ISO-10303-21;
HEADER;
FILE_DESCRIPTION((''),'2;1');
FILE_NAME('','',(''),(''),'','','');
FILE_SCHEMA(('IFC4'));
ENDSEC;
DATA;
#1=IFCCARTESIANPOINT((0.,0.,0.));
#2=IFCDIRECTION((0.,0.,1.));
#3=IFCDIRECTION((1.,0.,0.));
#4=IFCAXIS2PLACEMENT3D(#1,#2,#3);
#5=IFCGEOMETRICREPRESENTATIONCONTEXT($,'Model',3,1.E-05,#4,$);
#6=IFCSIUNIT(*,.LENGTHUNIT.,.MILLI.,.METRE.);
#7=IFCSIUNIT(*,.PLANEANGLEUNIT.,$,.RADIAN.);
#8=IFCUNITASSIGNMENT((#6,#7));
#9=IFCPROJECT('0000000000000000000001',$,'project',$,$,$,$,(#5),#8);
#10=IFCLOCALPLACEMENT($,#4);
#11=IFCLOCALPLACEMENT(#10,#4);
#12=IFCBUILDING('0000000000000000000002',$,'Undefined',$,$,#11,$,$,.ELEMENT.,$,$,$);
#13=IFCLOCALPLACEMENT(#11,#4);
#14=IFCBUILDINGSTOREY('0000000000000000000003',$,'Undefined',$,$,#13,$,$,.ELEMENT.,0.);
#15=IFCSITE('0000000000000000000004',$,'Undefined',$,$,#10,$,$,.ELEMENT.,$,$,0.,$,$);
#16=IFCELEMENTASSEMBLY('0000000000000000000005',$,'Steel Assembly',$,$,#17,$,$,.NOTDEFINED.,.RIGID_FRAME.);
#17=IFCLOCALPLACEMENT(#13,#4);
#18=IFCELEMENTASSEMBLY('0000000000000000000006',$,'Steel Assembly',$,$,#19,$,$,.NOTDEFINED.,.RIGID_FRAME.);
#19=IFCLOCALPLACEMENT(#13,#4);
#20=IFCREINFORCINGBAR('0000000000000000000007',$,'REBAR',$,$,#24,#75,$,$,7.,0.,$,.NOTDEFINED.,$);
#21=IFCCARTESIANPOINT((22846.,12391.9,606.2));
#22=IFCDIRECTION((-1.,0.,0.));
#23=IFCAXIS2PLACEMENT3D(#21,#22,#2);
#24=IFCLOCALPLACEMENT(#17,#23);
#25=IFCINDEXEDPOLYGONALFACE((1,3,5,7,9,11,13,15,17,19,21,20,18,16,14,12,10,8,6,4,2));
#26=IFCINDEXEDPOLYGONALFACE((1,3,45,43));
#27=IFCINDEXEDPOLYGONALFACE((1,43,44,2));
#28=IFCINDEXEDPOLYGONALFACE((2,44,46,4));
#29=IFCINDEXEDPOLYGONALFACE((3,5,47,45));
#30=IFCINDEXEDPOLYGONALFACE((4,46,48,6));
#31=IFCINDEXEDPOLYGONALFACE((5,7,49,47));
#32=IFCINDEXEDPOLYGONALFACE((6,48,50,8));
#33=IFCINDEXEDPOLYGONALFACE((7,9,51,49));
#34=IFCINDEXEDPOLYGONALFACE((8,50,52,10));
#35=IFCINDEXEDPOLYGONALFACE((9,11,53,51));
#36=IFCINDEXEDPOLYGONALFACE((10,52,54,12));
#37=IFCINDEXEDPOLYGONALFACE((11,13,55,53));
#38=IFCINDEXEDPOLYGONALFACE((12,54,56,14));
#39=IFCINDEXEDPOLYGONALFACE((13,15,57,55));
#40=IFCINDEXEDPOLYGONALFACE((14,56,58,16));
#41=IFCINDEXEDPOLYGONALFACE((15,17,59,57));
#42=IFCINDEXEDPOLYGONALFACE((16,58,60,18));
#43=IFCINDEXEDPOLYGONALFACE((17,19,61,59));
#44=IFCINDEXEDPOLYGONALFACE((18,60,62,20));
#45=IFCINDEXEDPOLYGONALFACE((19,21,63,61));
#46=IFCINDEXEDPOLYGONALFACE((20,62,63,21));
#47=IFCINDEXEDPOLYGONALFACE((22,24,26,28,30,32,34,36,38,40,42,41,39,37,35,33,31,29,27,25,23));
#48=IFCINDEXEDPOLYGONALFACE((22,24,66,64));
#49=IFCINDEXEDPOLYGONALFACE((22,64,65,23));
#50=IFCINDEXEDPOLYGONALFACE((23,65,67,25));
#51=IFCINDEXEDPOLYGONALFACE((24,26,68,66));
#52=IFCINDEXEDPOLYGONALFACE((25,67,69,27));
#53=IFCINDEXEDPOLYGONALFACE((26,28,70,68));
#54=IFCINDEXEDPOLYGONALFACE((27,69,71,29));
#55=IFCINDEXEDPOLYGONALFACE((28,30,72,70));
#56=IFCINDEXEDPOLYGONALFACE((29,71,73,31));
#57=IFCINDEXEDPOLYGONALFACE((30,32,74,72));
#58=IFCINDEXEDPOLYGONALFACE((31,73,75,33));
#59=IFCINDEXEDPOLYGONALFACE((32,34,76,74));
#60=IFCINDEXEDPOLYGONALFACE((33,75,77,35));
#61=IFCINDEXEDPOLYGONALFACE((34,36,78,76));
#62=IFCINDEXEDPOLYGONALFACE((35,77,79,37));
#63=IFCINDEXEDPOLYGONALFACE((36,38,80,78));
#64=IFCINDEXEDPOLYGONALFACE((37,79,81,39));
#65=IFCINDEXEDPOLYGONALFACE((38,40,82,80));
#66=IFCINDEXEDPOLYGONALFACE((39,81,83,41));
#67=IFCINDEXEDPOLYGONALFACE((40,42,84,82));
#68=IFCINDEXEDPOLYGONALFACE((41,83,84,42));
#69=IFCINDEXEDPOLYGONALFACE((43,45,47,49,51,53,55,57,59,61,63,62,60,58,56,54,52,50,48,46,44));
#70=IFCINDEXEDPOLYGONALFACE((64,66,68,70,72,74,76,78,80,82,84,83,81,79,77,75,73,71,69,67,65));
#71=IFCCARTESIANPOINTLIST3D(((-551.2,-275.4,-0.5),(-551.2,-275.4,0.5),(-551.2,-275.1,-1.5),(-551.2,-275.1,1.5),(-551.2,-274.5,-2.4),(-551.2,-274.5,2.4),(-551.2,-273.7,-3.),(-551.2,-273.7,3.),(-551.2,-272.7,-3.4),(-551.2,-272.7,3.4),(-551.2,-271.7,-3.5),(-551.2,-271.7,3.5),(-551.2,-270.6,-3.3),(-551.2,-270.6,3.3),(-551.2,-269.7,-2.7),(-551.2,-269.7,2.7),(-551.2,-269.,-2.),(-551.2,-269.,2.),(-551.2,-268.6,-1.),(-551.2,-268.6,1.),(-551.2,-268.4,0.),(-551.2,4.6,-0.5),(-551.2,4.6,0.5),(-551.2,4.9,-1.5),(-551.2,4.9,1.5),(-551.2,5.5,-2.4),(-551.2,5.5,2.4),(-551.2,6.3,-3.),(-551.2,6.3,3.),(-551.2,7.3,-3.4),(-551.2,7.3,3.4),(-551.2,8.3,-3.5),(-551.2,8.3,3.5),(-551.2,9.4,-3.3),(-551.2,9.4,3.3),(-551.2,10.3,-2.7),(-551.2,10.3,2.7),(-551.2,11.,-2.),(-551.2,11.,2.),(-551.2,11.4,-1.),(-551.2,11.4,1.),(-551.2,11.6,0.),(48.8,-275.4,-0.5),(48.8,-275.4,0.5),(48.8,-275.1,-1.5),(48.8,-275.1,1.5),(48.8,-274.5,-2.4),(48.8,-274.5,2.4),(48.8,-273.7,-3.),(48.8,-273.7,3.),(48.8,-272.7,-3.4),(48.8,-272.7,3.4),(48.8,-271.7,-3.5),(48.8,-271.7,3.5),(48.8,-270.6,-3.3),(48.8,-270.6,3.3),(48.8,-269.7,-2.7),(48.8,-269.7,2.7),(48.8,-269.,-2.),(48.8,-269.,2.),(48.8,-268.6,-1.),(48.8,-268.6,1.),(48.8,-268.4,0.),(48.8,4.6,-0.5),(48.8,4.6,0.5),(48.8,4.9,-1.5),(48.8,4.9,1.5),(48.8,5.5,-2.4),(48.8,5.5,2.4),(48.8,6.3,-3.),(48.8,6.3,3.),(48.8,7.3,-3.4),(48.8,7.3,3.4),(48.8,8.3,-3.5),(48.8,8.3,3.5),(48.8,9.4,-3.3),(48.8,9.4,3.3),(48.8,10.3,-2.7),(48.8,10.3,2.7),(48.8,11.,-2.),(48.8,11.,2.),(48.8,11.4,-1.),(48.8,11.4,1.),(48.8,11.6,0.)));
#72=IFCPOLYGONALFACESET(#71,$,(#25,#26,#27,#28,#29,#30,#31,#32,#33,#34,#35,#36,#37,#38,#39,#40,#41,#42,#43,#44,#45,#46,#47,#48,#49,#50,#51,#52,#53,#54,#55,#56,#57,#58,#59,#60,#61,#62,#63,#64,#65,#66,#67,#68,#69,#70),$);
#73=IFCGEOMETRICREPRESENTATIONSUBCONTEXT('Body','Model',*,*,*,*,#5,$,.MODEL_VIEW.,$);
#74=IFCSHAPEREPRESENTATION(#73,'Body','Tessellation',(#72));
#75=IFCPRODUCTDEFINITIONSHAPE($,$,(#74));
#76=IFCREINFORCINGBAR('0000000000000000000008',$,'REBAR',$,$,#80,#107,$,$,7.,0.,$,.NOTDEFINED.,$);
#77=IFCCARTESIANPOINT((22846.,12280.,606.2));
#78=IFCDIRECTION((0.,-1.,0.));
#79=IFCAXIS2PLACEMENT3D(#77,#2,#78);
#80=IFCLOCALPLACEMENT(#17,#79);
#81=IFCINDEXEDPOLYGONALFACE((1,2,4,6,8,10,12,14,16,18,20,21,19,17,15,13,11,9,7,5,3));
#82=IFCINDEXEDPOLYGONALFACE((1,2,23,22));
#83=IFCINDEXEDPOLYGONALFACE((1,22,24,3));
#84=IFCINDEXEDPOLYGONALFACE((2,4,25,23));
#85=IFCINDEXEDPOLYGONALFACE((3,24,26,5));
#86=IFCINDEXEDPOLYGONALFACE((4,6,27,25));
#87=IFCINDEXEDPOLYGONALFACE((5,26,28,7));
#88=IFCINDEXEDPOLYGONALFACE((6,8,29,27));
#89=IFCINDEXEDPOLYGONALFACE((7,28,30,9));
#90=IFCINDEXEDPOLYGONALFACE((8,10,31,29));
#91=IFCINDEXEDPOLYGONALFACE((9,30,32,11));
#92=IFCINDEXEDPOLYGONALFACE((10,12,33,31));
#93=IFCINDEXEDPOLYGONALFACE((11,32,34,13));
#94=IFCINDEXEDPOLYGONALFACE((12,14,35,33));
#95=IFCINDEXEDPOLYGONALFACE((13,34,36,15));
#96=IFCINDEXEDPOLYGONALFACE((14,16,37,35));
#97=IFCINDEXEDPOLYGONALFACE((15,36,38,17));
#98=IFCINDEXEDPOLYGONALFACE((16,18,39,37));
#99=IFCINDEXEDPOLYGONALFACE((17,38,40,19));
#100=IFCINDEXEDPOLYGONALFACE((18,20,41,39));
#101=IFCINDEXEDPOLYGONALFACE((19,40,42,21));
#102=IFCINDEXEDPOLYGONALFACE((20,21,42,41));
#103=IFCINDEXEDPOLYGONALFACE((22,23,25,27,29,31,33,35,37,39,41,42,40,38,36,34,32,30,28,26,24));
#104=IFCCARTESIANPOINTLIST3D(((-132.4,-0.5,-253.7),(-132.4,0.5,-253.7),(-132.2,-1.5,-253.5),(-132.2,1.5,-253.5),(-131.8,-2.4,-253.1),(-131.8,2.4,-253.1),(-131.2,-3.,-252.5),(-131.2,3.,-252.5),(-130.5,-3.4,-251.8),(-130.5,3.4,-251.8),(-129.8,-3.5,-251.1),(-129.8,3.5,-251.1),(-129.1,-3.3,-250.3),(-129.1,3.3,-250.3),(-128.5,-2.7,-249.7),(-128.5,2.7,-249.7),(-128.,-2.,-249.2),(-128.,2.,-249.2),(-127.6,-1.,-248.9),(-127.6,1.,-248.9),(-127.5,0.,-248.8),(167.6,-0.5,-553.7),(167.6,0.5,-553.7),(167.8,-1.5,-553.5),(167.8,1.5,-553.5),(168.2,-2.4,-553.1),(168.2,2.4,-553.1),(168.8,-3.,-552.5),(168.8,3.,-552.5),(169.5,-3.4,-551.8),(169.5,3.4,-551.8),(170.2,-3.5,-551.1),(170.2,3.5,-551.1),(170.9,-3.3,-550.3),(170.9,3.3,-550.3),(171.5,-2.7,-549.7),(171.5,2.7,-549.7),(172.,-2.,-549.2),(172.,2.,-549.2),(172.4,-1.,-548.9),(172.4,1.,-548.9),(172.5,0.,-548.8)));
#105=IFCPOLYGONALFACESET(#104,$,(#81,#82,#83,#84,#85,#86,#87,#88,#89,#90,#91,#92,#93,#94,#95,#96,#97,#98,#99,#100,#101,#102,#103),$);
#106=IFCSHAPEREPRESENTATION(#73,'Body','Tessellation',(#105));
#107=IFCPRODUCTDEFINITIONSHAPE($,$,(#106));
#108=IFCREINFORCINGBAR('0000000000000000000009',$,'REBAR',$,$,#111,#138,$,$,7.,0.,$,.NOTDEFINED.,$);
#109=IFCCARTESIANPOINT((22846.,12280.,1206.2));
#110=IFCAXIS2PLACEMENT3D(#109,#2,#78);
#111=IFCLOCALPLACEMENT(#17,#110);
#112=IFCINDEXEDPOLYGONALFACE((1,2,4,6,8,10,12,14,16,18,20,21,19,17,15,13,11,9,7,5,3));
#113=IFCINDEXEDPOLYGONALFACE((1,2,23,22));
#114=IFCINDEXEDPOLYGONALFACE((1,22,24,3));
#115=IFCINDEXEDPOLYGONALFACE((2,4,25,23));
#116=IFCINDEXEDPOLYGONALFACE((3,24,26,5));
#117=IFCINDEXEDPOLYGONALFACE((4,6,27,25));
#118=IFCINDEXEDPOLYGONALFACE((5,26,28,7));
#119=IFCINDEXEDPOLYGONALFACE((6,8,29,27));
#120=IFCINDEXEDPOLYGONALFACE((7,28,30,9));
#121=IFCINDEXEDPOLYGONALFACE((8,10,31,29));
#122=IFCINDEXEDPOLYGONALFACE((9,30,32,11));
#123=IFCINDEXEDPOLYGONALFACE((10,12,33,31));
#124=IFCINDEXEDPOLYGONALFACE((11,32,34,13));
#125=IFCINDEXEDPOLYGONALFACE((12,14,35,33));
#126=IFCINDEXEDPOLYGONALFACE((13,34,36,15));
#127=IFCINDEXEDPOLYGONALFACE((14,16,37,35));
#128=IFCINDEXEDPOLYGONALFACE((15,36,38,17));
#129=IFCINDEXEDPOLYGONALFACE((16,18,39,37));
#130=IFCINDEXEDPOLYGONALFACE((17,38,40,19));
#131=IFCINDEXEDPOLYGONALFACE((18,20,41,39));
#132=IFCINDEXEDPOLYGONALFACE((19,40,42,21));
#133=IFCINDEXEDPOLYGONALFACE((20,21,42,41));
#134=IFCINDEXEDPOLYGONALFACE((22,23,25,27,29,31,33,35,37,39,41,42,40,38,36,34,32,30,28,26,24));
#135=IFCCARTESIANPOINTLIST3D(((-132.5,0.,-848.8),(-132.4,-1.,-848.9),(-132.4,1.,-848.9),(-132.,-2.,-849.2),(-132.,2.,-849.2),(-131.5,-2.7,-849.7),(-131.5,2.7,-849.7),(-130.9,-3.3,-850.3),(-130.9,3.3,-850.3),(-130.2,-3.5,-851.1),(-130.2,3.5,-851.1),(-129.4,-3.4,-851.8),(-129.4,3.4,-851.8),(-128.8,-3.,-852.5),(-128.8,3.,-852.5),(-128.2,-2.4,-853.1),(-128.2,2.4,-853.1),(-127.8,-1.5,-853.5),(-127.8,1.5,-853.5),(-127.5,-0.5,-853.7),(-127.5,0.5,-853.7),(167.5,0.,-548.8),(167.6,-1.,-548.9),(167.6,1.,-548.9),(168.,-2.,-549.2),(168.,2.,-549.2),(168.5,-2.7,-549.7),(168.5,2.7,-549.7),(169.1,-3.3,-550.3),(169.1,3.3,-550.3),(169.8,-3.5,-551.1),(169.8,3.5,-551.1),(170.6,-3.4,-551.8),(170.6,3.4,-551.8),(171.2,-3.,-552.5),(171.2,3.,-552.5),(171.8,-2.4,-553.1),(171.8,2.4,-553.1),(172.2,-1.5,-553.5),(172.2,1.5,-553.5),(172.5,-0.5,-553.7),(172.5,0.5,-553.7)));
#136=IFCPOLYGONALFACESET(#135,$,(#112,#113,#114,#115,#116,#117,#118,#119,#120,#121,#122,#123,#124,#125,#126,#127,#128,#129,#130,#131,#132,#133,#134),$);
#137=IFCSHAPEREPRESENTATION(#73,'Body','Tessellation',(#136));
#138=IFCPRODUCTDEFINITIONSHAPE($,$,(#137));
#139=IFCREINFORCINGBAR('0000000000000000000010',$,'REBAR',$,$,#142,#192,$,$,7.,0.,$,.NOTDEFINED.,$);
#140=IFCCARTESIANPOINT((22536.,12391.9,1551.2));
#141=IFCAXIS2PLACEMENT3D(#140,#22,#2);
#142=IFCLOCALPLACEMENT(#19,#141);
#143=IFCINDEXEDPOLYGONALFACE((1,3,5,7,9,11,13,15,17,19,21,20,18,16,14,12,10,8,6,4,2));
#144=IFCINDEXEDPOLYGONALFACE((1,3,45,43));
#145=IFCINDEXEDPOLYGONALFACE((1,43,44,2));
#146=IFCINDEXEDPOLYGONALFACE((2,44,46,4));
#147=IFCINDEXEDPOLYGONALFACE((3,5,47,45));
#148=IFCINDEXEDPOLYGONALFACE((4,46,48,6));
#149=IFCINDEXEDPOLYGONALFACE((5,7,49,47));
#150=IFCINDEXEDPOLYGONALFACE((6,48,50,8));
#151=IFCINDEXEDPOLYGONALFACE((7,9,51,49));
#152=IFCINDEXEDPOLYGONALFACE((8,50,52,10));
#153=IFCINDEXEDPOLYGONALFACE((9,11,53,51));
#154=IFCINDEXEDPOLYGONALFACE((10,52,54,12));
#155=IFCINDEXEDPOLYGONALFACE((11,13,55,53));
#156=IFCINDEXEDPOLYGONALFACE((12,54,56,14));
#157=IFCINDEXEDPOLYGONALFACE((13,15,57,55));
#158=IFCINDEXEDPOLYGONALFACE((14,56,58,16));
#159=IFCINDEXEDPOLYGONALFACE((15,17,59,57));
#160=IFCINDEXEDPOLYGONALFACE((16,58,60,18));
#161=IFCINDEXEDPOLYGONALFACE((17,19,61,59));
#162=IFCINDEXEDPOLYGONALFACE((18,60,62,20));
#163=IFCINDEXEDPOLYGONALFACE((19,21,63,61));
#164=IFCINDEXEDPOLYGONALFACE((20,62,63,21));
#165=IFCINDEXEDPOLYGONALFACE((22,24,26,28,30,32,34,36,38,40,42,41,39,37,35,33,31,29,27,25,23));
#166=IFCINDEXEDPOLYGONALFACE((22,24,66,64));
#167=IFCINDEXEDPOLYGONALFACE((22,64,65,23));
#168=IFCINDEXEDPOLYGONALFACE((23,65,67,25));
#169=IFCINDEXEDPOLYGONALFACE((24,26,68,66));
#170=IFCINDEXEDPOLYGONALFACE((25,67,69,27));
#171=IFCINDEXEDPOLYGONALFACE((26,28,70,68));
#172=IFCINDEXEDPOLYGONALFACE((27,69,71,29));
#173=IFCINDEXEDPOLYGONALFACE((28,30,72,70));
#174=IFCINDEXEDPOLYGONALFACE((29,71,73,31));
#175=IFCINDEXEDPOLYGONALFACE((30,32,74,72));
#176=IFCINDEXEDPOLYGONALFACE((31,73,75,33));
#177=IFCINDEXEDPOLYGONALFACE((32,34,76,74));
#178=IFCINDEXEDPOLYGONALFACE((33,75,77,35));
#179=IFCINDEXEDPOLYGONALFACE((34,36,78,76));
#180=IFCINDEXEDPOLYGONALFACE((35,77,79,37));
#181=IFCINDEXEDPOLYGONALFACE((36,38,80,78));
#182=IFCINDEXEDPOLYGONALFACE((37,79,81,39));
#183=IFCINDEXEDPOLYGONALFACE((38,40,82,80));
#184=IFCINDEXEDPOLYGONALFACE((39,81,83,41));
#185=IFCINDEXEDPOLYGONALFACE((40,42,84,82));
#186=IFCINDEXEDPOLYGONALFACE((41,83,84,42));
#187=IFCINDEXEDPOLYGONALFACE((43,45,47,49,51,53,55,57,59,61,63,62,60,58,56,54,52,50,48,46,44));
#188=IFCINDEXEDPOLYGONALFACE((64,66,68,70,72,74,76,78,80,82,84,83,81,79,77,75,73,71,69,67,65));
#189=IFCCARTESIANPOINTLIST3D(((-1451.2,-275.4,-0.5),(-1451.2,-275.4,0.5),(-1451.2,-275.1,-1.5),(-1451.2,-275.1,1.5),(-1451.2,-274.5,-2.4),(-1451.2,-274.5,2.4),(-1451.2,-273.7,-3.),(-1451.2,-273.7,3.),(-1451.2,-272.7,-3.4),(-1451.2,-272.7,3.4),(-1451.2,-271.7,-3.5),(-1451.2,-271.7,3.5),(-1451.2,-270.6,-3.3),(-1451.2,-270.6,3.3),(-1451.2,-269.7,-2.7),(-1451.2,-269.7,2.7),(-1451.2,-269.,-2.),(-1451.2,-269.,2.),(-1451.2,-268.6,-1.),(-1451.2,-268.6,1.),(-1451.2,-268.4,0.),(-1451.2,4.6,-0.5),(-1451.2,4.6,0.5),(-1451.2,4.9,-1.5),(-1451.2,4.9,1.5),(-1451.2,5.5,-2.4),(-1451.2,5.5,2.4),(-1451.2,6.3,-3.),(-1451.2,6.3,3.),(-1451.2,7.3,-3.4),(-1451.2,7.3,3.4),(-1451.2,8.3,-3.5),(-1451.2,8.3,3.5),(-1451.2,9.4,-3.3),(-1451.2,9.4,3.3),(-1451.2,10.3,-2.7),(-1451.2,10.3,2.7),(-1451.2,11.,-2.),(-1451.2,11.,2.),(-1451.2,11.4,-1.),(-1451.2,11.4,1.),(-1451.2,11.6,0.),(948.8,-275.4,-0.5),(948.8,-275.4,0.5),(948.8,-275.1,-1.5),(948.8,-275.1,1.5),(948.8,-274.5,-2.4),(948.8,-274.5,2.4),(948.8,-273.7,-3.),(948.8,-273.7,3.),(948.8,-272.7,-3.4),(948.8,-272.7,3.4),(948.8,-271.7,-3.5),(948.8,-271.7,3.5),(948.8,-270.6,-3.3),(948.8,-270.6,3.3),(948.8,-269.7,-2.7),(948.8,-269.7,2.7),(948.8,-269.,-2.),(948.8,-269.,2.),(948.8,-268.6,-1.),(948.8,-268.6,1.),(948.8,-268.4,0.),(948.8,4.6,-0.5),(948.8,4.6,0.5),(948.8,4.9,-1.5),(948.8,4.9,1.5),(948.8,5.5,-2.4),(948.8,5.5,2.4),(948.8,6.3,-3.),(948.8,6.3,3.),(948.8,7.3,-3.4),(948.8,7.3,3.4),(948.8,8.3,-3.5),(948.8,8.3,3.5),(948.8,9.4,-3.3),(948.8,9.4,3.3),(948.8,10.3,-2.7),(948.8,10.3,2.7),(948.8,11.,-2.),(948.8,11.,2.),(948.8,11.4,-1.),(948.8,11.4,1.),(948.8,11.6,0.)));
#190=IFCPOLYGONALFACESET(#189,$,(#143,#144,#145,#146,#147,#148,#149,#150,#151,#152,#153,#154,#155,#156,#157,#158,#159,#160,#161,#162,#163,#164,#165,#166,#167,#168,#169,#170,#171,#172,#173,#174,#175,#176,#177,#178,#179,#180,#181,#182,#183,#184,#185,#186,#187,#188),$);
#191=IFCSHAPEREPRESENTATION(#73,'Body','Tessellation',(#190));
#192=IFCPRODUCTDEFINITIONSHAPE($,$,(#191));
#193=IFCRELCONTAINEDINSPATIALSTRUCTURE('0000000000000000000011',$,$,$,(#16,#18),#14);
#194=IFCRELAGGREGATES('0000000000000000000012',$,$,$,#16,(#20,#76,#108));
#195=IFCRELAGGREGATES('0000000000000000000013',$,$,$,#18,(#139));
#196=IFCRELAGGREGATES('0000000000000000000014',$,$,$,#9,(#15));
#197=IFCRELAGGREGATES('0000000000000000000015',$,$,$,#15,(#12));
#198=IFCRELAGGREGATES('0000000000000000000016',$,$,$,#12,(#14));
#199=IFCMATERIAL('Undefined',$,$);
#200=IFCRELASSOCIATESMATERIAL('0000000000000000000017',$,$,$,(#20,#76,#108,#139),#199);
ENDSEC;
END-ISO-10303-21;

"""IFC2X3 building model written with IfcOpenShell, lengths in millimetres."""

from ifc_helpers import new_model, entity, si_unit, frame, origin_with_axes, place, context, subcontext, project, spatial, source, transform, mapped, material, element, aggregate, save


model = new_model("IFC2X3")

# Units and contexts
model_context = context("Model", 3, precision=1e-05, world=origin_with_axes())
body_context = subcontext(model_context, "Body", "Model", "MODEL_VIEW")
ifc_project = project(units=[si_unit("LENGTHUNIT", "METRE", prefix="MILLI"), si_unit("PLANEANGLEUNIT", "RADIAN")], contexts=[model_context])

# Site, building, storey
site_placement = place(None, origin_with_axes())
site = spatial("IfcSite", under=ifc_project, at=site_placement, Name="Undefined", CompositionType="ELEMENT", RefElevation=0.0)
building_placement = place(site_placement, origin_with_axes())
building = spatial("IfcBuilding", under=site, at=building_placement, Name="Undefined", CompositionType="ELEMENT")
storey_placement = place(building_placement, origin_with_axes())
storey = spatial("IfcBuildingStorey", under=building, at=storey_placement, Name="Undefined", CompositionType="ELEMENT", Elevation=0.0)

# Element assemblies
assembly_1_placement = place(storey_placement, origin_with_axes())
assembly_1 = element("IfcElementAssembly", 1, at=assembly_1_placement, inside=storey, Name="Steel Assembly", AssemblyPlace="NOTDEFINED", PredefinedType="RIGID_FRAME")
assembly_2_placement = place(storey_placement, origin_with_axes())
assembly_2 = element("IfcElementAssembly", 2, at=assembly_2_placement, inside=storey, Name="Steel Assembly", AssemblyPlace="NOTDEFINED", PredefinedType="RIGID_FRAME")

# Shared definitions
ifc_material_1 = material(Name="Undefined")

# Reinforcing bars
shared_shape_1 = source(origin_with_axes(), body_context, "Body", "AdvancedSweptSolid", [
    entity("IfcSweptDiskSolid", entity("IfcTrimmedCurve", entity("IfcLine", entity("IfcCartesianPoint", [0.0, 0.0, 0.0]), entity("IfcVector", entity("IfcDirection", [1.0, 0.00001, 0.0]), 1.0)), [entity("IfcParameterValue", 0.0)], [entity("IfcParameterValue", 600.0)], True, "PARAMETER"), 3.5, None, 0.0, 600.0),
])
shared_shape_2 = source(origin_with_axes(), body_context, "Body", "AdvancedSweptSolid", [
    entity("IfcSweptDiskSolid", entity("IfcTrimmedCurve", entity("IfcLine", entity("IfcCartesianPoint", [0.0, 0.0, 0.0]), entity("IfcVector", entity("IfcDirection", [1.0, 0.00001, 0.0]), 1.0)), [entity("IfcParameterValue", 0.0)], [entity("IfcParameterValue", 600.0)], True, "PARAMETER"), 3.5, None, 0.0, 600.0),
])
reinforcing_bar_1_placement = place(assembly_1_placement, frame((22846.0, 12391.9, 606.2), z_axis=(-1.0, 0.0, 0.0), x_axis=(0.0, 0.0, 1.0)))
reinforcing_bar_1 = element("IfcReinforcingBar", 3, at=reinforcing_bar_1_placement, material=ifc_material_1, Name="REBAR", BarRole="NOTDEFINED", CrossSectionArea=0.0, NominalDiameter=7.0, context=body_context, shape_type="MappedRepresentation", body=[
    mapped(shared_shape_1, transform((-551.2, -271.9, 0.0))),
    mapped(shared_shape_2, transform((-551.2, 8.1, 0.0))),
])
shared_shape_3 = source(origin_with_axes(), body_context, "Body", "AdvancedSweptSolid", [
    entity("IfcSweptDiskSolid", entity("IfcTrimmedCurve", entity("IfcLine", entity("IfcCartesianPoint", [0.0, 0.0, 0.0]), entity("IfcVector", entity("IfcDirection", [0.707107, 0.0, -0.707107]), 1.0)), [entity("IfcParameterValue", 0.0)], [entity("IfcParameterValue", 424.264069)], True, "PARAMETER"), 3.5, None, 0.0, 424.3),
])
reinforcing_bar_2_placement = place(assembly_1_placement, frame((22846.0, 12280.0, 606.2), z_axis=(0.0, 0.0, 1.0), x_axis=(0.0, -1.0, 0.0)))
reinforcing_bar_2 = element("IfcReinforcingBar", 4, at=reinforcing_bar_2_placement, material=ifc_material_1, Name="REBAR", BarRole="NOTDEFINED", CrossSectionArea=0.0, NominalDiameter=7.0, context=body_context, shape_type="MappedRepresentation", body=[
    mapped(shared_shape_3, transform((-130.0, 0.0, -251.2))),
])
shared_shape_4 = source(origin_with_axes(), body_context, "Body", "AdvancedSweptSolid", [
    entity("IfcSweptDiskSolid", entity("IfcTrimmedCurve", entity("IfcLine", entity("IfcCartesianPoint", [0.0, 0.0, 0.0]), entity("IfcVector", entity("IfcDirection", [0.707107, 0.0, 0.707107]), 1.0)), [entity("IfcParameterValue", 0.0)], [entity("IfcParameterValue", 424.264069)], True, "PARAMETER"), 3.5, None, 0.0, 424.3),
])
reinforcing_bar_3_placement = place(assembly_1_placement, frame((22846.0, 12280.0, 1206.2), z_axis=(0.0, 0.0, 1.0), x_axis=(0.0, -1.0, 0.0)))
reinforcing_bar_3 = element("IfcReinforcingBar", 5, at=reinforcing_bar_3_placement, material=ifc_material_1, Name="REBAR", BarRole="NOTDEFINED", CrossSectionArea=0.0, NominalDiameter=7.0, context=body_context, shape_type="MappedRepresentation", body=[
    mapped(shared_shape_4, transform((-130.0, 0.0, -851.2))),
])
aggregate(assembly_1, [reinforcing_bar_1, reinforcing_bar_2, reinforcing_bar_3])
shared_shape_5 = source(origin_with_axes(), body_context, "Body", "AdvancedSweptSolid", [
    entity("IfcSweptDiskSolid", entity("IfcTrimmedCurve", entity("IfcLine", entity("IfcCartesianPoint", [0.0, 0.0, 0.0]), entity("IfcVector", entity("IfcDirection", [1.0, 0.000003, 0.0]), 1.0)), [entity("IfcParameterValue", 0.0)], [entity("IfcParameterValue", 2400.0)], True, "PARAMETER"), 3.5, None, 0.0, 2400.0),
])
shared_shape_6 = source(origin_with_axes(), body_context, "Body", "AdvancedSweptSolid", [
    entity("IfcSweptDiskSolid", entity("IfcTrimmedCurve", entity("IfcLine", entity("IfcCartesianPoint", [0.0, 0.0, 0.0]), entity("IfcVector", entity("IfcDirection", [1.0, 0.000003, 0.0]), 1.0)), [entity("IfcParameterValue", 0.0)], [entity("IfcParameterValue", 2400.0)], True, "PARAMETER"), 3.5, None, 0.0, 2400.0),
])
reinforcing_bar_4_placement = place(assembly_2_placement, frame((22536.0, 12391.9, 1551.2), z_axis=(-1.0, 0.0, 0.0), x_axis=(0.0, 0.0, 1.0)))
reinforcing_bar_4 = element("IfcReinforcingBar", 6, at=reinforcing_bar_4_placement, material=ifc_material_1, Name="REBAR", BarRole="NOTDEFINED", CrossSectionArea=0.0, NominalDiameter=7.0, context=body_context, shape_type="MappedRepresentation", body=[
    mapped(shared_shape_5, transform((-1451.2, -271.9, 0.0))),
    mapped(shared_shape_6, transform((-1451.2, 8.1, 0.0))),
])
aggregate(assembly_2, [reinforcing_bar_4])

save(model, "model.ifc")
